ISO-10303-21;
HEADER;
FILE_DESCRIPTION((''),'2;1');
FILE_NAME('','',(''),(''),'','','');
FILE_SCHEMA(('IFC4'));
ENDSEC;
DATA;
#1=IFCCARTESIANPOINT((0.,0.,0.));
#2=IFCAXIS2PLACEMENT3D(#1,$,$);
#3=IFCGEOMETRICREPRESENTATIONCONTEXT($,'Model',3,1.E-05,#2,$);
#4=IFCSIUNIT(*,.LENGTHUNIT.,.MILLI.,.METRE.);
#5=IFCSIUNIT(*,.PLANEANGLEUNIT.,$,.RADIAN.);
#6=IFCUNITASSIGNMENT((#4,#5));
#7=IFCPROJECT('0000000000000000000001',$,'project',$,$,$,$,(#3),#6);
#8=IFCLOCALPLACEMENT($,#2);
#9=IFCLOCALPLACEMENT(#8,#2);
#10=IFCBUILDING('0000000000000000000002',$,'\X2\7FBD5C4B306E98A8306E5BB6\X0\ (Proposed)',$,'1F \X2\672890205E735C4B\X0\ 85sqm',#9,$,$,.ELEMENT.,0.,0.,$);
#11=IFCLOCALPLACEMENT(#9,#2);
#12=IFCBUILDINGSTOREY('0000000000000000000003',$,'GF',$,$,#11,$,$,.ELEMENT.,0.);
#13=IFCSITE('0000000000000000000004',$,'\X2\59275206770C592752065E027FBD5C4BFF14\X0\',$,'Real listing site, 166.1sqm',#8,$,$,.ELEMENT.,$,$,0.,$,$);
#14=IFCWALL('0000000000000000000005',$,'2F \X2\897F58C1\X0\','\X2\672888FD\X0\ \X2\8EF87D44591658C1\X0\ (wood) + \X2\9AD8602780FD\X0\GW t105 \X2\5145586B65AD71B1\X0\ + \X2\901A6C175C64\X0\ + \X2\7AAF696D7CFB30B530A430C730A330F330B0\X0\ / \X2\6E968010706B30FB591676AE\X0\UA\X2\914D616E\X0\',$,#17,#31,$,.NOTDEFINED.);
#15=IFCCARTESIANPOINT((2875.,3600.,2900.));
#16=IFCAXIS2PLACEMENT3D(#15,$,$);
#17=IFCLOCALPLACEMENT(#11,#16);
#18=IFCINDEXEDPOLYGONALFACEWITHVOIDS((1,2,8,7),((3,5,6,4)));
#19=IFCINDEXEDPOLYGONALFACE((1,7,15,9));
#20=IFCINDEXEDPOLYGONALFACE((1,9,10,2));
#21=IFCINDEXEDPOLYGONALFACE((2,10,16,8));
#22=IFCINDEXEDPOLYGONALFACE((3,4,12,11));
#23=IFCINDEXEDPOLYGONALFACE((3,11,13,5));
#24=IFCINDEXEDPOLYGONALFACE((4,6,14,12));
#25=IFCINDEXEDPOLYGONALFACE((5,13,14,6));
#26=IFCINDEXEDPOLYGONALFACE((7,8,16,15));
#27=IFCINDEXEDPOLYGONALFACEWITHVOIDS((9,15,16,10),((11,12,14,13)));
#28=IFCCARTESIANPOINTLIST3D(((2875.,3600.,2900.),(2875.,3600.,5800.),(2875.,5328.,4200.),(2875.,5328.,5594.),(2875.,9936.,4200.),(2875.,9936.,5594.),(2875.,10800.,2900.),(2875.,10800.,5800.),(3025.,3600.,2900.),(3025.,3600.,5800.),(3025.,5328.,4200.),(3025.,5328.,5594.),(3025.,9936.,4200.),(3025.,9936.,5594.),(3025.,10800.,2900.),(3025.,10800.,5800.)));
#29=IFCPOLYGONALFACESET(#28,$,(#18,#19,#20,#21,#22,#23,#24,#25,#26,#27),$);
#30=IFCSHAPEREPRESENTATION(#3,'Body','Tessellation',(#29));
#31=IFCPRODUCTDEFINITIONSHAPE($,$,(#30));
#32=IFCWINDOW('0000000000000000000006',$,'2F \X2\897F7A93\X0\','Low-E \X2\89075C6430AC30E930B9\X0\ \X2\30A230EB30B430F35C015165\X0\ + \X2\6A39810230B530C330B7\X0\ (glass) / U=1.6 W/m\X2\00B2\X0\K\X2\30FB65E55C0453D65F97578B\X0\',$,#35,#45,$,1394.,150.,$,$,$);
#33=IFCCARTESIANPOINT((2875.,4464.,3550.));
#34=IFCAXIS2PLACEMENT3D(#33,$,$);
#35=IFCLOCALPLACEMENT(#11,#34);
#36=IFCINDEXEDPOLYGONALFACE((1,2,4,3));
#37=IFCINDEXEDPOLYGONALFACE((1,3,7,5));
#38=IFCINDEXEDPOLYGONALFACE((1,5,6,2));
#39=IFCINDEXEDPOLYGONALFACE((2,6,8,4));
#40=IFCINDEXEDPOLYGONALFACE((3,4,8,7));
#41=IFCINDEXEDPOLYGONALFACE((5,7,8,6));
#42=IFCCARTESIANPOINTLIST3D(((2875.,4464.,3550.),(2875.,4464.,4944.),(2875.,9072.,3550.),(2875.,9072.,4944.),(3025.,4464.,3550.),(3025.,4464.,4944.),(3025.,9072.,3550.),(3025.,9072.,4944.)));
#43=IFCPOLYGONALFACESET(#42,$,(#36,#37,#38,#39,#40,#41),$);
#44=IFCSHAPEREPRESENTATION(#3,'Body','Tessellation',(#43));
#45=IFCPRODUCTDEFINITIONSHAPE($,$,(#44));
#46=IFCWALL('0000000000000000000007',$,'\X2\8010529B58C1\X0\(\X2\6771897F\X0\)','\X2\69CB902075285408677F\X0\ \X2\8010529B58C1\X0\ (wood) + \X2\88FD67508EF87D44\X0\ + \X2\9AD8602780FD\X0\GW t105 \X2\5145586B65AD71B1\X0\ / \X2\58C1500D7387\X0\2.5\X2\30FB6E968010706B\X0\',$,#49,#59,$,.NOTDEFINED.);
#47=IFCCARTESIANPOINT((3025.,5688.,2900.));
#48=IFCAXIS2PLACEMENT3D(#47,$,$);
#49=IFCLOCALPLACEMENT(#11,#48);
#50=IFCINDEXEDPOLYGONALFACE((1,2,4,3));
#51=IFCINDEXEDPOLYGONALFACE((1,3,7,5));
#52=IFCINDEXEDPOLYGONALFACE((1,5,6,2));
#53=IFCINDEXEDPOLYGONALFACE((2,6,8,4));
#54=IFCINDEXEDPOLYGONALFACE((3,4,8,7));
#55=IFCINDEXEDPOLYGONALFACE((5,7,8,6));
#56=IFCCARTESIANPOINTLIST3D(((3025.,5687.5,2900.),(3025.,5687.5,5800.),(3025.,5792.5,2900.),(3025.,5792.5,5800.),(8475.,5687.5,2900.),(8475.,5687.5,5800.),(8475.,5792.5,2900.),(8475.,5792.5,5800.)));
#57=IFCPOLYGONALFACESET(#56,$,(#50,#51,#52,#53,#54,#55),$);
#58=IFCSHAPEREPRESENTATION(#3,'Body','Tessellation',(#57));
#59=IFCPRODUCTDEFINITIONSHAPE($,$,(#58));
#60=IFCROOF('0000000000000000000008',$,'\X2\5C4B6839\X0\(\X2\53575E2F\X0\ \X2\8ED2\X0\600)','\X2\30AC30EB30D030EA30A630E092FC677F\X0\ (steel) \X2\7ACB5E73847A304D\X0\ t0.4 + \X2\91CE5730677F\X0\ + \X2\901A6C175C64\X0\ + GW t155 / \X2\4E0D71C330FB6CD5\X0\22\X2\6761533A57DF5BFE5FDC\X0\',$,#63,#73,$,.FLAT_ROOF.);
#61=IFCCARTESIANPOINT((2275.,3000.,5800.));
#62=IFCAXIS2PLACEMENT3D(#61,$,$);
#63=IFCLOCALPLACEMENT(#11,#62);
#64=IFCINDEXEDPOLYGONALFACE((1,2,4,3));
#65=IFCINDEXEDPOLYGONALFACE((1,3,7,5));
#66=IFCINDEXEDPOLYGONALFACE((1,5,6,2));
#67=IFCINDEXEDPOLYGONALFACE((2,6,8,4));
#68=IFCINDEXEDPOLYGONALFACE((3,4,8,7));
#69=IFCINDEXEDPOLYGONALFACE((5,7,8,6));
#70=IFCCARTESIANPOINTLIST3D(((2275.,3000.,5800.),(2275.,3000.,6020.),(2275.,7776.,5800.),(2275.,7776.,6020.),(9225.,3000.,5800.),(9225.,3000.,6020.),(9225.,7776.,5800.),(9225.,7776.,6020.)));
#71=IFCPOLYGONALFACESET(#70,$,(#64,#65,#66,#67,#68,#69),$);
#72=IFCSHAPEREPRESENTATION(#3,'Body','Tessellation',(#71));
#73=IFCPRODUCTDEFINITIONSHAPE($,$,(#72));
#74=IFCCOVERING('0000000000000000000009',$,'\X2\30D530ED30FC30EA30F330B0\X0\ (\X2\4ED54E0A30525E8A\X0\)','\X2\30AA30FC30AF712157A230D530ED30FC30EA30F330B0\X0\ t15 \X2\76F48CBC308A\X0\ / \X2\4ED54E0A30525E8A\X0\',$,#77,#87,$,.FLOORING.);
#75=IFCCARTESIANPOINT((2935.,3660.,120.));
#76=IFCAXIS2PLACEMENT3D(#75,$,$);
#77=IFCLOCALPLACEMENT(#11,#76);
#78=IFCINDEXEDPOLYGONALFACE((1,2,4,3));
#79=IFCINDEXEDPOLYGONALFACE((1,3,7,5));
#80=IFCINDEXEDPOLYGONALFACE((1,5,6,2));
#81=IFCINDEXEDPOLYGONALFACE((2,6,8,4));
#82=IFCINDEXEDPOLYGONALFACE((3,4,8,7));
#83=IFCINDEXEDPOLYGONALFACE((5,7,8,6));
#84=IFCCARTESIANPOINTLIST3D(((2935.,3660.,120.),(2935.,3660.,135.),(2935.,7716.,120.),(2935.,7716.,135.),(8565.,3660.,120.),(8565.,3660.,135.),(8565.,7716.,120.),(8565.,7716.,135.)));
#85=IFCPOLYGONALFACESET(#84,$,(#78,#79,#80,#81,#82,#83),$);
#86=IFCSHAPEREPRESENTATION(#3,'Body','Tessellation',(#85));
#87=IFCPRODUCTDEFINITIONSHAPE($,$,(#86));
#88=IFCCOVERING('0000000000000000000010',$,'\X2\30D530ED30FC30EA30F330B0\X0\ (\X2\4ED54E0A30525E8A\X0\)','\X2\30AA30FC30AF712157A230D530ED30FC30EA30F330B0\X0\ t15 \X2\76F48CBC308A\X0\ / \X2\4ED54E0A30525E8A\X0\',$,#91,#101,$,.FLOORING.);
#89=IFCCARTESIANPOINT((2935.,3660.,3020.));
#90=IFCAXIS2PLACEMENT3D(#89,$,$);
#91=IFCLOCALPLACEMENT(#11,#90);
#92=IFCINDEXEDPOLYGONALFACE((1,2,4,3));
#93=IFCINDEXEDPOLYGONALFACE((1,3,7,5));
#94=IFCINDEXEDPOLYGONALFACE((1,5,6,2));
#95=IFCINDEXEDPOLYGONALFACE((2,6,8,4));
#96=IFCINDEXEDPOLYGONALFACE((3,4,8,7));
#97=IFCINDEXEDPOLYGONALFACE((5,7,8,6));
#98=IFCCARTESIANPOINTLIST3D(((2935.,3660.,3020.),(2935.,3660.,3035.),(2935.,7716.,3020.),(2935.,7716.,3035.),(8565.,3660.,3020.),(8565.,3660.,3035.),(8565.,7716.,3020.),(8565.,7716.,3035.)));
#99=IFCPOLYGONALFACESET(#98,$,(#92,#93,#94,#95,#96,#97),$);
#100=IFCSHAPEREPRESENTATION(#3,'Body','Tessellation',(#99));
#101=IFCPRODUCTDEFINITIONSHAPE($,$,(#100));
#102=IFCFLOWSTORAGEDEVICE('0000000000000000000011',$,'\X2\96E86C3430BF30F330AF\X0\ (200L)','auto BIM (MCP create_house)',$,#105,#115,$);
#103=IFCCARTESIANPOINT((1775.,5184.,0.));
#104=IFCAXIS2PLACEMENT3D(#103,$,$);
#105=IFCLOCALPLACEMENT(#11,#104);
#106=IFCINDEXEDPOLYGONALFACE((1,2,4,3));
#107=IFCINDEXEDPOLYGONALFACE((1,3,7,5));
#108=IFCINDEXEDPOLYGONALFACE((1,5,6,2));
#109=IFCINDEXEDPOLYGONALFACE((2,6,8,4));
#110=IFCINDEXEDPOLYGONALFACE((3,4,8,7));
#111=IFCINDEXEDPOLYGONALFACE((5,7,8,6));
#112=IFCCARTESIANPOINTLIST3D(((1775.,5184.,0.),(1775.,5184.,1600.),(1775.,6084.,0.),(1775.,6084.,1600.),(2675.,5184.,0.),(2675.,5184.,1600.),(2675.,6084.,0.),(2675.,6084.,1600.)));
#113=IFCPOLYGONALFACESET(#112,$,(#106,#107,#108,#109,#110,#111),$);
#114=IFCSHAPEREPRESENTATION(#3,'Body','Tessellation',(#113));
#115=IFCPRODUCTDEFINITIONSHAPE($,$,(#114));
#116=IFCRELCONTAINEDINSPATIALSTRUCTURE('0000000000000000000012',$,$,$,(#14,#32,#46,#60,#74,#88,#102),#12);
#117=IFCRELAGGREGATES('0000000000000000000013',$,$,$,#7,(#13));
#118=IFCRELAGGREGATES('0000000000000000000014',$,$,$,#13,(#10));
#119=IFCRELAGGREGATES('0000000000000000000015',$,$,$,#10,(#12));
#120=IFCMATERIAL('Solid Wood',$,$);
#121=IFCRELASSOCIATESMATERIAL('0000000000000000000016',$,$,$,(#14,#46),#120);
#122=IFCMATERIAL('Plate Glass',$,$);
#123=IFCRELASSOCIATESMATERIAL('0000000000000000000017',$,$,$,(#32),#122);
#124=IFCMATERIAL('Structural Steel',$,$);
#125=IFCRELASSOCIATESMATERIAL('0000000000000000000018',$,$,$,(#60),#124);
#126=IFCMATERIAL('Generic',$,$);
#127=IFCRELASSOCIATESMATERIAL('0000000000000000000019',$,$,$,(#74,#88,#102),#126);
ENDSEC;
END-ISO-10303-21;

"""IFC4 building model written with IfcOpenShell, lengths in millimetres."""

from ifc_helpers import new_model, si_unit, frame, frame_2d, origin, place, context, project, spatial, rectangle, extrude, material, element, fill, save


model = new_model("IFC4")

# Units and contexts
model_context = context("Model", 3, precision=1e-05, world=origin())
ifc_project = project(units=[si_unit("LENGTHUNIT", "METRE", prefix="MILLI"), si_unit("PLANEANGLEUNIT", "RADIAN")], contexts=[model_context])

# Site, building, storey
site_placement = place(None, origin())
site = spatial("IfcSite", under=ifc_project, at=site_placement, Name="大分県大分市羽屋４", ObjectType="Real listing site, 166.1sqm", CompositionType="ELEMENT", RefElevation=0.0)
building_placement = place(site_placement, origin())
building = spatial("IfcBuilding", under=site, at=building_placement, Name="羽屋の風の家 (Proposed)", ObjectType="1F 木造平屋 85sqm", CompositionType="ELEMENT", ElevationOfRefHeight=0.0, ElevationOfTerrain=0.0)
storey_placement = place(building_placement, origin())
storey = spatial("IfcBuildingStorey", under=building, at=storey_placement, Name="GF", CompositionType="ELEMENT", Elevation=0.0)

# Shared definitions
ifc_material_1 = material(Name="Solid Wood")
ifc_material_2 = material(Name="Generic")

# Shared definitions
ifc_material_3 = material(Name="Plate Glass")

# Wall, opening, window
wall_1_placement = place(storey_placement, frame((2875.0, 3600.0, 2900.0)))
wall_1 = element("IfcWall", 1, at=wall_1_placement, inside=storey, material=ifc_material_1, Name="2F 西壁", Description="木製 軸組外壁 (wood) + 高性能GW t105 充填断熱 + 通気層 + 窯業系サイディング / 準耐火・外皮UA配慮", PredefinedType="NOTDEFINED", context=model_context, shape_type="SweptSolid", body=[
    extrude(rectangle(XDim=150.0, YDim=7200.0, at=frame_2d((75.0, 3600.0))), frame((2875.0, 3600.0, 2900.0)), (0.0, 0.0, 1.0), 2900.0),
])
opening_1_placement = place(storey_placement, frame((2875.0, 4464.0, 3550.0)))
opening_1 = element("IfcOpeningElement", 2, at=opening_1_placement, cuts=wall_1, PredefinedType="NOTDEFINED", context=model_context, shape_type="SweptSolid", body=[
    extrude(rectangle(XDim=150.0, YDim=4608.0, at=frame_2d((75.0, 2304.0))), frame((2875.0, 4464.0, 3550.0)), (0.0, 0.0, 1.0), 1394.0),
])
window_1_placement = place(storey_placement, frame((2875.0, 4464.0, 3550.0)))
window_1 = element("IfcWindow", 3, at=window_1_placement, inside=storey, material=ifc_material_3, Name="2F 西窓", Description="Low-E 複層ガラス アルゴン封入 + 樹脂サッシ (glass) / U=1.6 W/m²K・日射取得型", OverallHeight=1394.0, OverallWidth=150.0, context=model_context, shape_type="SweptSolid", body=[
    extrude(rectangle(XDim=150.0, YDim=4608.0, at=frame_2d((75.0, 2304.0))), frame((2875.0, 4464.0, 3550.0)), (0.0, 0.0, 1.0), 1394.0),
])
fill(opening_1, window_1)

# Wall
wall_2_placement = place(storey_placement, frame((3025.0, 5688.0, 2900.0)))
element("IfcWall", 4, at=wall_2_placement, inside=storey, material=ifc_material_1, Name="耐力壁(東西)", Description="構造用合板 耐力壁 (wood) + 製材軸組 + 高性能GW t105 充填断熱 / 壁倍率2.5・準耐火", PredefinedType="NOTDEFINED", context=model_context, shape_type="SweptSolid", body=[
    extrude(rectangle(XDim=5450.0, YDim=105.0, at=frame_2d((2725.0, 52.0))), frame((3025.0, 5688.0, 2900.0)), (0.0, 0.0, 1.0), 2900.0),
])

# Roof
ifc_material_4 = material(Name="Structural Steel")
for number, where, name in (
    (5, (2275.0, 3000.0, 5800.0), "屋根(南帯 軒600)"),
):
    element("IfcRoof", number, at=place(storey_placement, frame(where)), inside=storey, material=ifc_material_4, Name=name, Description="ガルバリウム鋼板 (steel) 立平葺き t0.4 + 野地板 + 通気層 + GW t155 / 不燃・法22条区域対応", PredefinedType="FLAT_ROOF", context=model_context, shape_type="SweptSolid", body=[
        extrude(rectangle(XDim=6950.0, YDim=4776.0, at=frame_2d((3475.0, 2388.0))), frame((2275.0, 3000.0, 5800.0)), (0.0, 0.0, 1.0), 220.0),
    ])

# Coverings
covering_1_placement = place(storey_placement, frame((2935.0, 3660.0, 120.0)))
element("IfcCovering", 6, at=covering_1_placement, inside=storey, material=ifc_material_2, Name="フローリング (仕上げ床)", Description="オーク無垢フローリング t15 直貼り / 仕上げ床", PredefinedType="FLOORING", context=model_context, shape_type="SweptSolid", body=[
    extrude(rectangle(XDim=5630.0, YDim=4056.0, at=frame_2d((2815.0, 2028.0))), frame((2935.0, 3660.0, 120.0)), (0.0, 0.0, 1.0), 15.0),
])
covering_2_placement = place(storey_placement, frame((2935.0, 3660.0, 3020.0)))
element("IfcCovering", 7, at=covering_2_placement, inside=storey, material=ifc_material_2, Name="フローリング (仕上げ床)", Description="オーク無垢フローリング t15 直貼り / 仕上げ床", PredefinedType="FLOORING", context=model_context, shape_type="SweptSolid", body=[
    extrude(rectangle(XDim=5630.0, YDim=4056.0, at=frame_2d((2815.0, 2028.0))), frame((2935.0, 3660.0, 3020.0)), (0.0, 0.0, 1.0), 15.0),
])

# Flow storage device
flow_storage_device_placement = place(storey_placement, frame((1775.0, 5184.0, 0.0)))
element("IfcFlowStorageDevice", 8, at=flow_storage_device_placement, inside=storey, material=ifc_material_2, Name="雨水タンク (200L)", Description="auto BIM (MCP create_house)", context=model_context, shape_type="SweptSolid", body=[
    extrude(rectangle(XDim=900.0, YDim=900.0, at=frame_2d((450.0, 450.0))), frame((1775.0, 5184.0, 0.0)), (0.0, 0.0, 1.0), 1600.0),
])

save(model, "model.ifc")
